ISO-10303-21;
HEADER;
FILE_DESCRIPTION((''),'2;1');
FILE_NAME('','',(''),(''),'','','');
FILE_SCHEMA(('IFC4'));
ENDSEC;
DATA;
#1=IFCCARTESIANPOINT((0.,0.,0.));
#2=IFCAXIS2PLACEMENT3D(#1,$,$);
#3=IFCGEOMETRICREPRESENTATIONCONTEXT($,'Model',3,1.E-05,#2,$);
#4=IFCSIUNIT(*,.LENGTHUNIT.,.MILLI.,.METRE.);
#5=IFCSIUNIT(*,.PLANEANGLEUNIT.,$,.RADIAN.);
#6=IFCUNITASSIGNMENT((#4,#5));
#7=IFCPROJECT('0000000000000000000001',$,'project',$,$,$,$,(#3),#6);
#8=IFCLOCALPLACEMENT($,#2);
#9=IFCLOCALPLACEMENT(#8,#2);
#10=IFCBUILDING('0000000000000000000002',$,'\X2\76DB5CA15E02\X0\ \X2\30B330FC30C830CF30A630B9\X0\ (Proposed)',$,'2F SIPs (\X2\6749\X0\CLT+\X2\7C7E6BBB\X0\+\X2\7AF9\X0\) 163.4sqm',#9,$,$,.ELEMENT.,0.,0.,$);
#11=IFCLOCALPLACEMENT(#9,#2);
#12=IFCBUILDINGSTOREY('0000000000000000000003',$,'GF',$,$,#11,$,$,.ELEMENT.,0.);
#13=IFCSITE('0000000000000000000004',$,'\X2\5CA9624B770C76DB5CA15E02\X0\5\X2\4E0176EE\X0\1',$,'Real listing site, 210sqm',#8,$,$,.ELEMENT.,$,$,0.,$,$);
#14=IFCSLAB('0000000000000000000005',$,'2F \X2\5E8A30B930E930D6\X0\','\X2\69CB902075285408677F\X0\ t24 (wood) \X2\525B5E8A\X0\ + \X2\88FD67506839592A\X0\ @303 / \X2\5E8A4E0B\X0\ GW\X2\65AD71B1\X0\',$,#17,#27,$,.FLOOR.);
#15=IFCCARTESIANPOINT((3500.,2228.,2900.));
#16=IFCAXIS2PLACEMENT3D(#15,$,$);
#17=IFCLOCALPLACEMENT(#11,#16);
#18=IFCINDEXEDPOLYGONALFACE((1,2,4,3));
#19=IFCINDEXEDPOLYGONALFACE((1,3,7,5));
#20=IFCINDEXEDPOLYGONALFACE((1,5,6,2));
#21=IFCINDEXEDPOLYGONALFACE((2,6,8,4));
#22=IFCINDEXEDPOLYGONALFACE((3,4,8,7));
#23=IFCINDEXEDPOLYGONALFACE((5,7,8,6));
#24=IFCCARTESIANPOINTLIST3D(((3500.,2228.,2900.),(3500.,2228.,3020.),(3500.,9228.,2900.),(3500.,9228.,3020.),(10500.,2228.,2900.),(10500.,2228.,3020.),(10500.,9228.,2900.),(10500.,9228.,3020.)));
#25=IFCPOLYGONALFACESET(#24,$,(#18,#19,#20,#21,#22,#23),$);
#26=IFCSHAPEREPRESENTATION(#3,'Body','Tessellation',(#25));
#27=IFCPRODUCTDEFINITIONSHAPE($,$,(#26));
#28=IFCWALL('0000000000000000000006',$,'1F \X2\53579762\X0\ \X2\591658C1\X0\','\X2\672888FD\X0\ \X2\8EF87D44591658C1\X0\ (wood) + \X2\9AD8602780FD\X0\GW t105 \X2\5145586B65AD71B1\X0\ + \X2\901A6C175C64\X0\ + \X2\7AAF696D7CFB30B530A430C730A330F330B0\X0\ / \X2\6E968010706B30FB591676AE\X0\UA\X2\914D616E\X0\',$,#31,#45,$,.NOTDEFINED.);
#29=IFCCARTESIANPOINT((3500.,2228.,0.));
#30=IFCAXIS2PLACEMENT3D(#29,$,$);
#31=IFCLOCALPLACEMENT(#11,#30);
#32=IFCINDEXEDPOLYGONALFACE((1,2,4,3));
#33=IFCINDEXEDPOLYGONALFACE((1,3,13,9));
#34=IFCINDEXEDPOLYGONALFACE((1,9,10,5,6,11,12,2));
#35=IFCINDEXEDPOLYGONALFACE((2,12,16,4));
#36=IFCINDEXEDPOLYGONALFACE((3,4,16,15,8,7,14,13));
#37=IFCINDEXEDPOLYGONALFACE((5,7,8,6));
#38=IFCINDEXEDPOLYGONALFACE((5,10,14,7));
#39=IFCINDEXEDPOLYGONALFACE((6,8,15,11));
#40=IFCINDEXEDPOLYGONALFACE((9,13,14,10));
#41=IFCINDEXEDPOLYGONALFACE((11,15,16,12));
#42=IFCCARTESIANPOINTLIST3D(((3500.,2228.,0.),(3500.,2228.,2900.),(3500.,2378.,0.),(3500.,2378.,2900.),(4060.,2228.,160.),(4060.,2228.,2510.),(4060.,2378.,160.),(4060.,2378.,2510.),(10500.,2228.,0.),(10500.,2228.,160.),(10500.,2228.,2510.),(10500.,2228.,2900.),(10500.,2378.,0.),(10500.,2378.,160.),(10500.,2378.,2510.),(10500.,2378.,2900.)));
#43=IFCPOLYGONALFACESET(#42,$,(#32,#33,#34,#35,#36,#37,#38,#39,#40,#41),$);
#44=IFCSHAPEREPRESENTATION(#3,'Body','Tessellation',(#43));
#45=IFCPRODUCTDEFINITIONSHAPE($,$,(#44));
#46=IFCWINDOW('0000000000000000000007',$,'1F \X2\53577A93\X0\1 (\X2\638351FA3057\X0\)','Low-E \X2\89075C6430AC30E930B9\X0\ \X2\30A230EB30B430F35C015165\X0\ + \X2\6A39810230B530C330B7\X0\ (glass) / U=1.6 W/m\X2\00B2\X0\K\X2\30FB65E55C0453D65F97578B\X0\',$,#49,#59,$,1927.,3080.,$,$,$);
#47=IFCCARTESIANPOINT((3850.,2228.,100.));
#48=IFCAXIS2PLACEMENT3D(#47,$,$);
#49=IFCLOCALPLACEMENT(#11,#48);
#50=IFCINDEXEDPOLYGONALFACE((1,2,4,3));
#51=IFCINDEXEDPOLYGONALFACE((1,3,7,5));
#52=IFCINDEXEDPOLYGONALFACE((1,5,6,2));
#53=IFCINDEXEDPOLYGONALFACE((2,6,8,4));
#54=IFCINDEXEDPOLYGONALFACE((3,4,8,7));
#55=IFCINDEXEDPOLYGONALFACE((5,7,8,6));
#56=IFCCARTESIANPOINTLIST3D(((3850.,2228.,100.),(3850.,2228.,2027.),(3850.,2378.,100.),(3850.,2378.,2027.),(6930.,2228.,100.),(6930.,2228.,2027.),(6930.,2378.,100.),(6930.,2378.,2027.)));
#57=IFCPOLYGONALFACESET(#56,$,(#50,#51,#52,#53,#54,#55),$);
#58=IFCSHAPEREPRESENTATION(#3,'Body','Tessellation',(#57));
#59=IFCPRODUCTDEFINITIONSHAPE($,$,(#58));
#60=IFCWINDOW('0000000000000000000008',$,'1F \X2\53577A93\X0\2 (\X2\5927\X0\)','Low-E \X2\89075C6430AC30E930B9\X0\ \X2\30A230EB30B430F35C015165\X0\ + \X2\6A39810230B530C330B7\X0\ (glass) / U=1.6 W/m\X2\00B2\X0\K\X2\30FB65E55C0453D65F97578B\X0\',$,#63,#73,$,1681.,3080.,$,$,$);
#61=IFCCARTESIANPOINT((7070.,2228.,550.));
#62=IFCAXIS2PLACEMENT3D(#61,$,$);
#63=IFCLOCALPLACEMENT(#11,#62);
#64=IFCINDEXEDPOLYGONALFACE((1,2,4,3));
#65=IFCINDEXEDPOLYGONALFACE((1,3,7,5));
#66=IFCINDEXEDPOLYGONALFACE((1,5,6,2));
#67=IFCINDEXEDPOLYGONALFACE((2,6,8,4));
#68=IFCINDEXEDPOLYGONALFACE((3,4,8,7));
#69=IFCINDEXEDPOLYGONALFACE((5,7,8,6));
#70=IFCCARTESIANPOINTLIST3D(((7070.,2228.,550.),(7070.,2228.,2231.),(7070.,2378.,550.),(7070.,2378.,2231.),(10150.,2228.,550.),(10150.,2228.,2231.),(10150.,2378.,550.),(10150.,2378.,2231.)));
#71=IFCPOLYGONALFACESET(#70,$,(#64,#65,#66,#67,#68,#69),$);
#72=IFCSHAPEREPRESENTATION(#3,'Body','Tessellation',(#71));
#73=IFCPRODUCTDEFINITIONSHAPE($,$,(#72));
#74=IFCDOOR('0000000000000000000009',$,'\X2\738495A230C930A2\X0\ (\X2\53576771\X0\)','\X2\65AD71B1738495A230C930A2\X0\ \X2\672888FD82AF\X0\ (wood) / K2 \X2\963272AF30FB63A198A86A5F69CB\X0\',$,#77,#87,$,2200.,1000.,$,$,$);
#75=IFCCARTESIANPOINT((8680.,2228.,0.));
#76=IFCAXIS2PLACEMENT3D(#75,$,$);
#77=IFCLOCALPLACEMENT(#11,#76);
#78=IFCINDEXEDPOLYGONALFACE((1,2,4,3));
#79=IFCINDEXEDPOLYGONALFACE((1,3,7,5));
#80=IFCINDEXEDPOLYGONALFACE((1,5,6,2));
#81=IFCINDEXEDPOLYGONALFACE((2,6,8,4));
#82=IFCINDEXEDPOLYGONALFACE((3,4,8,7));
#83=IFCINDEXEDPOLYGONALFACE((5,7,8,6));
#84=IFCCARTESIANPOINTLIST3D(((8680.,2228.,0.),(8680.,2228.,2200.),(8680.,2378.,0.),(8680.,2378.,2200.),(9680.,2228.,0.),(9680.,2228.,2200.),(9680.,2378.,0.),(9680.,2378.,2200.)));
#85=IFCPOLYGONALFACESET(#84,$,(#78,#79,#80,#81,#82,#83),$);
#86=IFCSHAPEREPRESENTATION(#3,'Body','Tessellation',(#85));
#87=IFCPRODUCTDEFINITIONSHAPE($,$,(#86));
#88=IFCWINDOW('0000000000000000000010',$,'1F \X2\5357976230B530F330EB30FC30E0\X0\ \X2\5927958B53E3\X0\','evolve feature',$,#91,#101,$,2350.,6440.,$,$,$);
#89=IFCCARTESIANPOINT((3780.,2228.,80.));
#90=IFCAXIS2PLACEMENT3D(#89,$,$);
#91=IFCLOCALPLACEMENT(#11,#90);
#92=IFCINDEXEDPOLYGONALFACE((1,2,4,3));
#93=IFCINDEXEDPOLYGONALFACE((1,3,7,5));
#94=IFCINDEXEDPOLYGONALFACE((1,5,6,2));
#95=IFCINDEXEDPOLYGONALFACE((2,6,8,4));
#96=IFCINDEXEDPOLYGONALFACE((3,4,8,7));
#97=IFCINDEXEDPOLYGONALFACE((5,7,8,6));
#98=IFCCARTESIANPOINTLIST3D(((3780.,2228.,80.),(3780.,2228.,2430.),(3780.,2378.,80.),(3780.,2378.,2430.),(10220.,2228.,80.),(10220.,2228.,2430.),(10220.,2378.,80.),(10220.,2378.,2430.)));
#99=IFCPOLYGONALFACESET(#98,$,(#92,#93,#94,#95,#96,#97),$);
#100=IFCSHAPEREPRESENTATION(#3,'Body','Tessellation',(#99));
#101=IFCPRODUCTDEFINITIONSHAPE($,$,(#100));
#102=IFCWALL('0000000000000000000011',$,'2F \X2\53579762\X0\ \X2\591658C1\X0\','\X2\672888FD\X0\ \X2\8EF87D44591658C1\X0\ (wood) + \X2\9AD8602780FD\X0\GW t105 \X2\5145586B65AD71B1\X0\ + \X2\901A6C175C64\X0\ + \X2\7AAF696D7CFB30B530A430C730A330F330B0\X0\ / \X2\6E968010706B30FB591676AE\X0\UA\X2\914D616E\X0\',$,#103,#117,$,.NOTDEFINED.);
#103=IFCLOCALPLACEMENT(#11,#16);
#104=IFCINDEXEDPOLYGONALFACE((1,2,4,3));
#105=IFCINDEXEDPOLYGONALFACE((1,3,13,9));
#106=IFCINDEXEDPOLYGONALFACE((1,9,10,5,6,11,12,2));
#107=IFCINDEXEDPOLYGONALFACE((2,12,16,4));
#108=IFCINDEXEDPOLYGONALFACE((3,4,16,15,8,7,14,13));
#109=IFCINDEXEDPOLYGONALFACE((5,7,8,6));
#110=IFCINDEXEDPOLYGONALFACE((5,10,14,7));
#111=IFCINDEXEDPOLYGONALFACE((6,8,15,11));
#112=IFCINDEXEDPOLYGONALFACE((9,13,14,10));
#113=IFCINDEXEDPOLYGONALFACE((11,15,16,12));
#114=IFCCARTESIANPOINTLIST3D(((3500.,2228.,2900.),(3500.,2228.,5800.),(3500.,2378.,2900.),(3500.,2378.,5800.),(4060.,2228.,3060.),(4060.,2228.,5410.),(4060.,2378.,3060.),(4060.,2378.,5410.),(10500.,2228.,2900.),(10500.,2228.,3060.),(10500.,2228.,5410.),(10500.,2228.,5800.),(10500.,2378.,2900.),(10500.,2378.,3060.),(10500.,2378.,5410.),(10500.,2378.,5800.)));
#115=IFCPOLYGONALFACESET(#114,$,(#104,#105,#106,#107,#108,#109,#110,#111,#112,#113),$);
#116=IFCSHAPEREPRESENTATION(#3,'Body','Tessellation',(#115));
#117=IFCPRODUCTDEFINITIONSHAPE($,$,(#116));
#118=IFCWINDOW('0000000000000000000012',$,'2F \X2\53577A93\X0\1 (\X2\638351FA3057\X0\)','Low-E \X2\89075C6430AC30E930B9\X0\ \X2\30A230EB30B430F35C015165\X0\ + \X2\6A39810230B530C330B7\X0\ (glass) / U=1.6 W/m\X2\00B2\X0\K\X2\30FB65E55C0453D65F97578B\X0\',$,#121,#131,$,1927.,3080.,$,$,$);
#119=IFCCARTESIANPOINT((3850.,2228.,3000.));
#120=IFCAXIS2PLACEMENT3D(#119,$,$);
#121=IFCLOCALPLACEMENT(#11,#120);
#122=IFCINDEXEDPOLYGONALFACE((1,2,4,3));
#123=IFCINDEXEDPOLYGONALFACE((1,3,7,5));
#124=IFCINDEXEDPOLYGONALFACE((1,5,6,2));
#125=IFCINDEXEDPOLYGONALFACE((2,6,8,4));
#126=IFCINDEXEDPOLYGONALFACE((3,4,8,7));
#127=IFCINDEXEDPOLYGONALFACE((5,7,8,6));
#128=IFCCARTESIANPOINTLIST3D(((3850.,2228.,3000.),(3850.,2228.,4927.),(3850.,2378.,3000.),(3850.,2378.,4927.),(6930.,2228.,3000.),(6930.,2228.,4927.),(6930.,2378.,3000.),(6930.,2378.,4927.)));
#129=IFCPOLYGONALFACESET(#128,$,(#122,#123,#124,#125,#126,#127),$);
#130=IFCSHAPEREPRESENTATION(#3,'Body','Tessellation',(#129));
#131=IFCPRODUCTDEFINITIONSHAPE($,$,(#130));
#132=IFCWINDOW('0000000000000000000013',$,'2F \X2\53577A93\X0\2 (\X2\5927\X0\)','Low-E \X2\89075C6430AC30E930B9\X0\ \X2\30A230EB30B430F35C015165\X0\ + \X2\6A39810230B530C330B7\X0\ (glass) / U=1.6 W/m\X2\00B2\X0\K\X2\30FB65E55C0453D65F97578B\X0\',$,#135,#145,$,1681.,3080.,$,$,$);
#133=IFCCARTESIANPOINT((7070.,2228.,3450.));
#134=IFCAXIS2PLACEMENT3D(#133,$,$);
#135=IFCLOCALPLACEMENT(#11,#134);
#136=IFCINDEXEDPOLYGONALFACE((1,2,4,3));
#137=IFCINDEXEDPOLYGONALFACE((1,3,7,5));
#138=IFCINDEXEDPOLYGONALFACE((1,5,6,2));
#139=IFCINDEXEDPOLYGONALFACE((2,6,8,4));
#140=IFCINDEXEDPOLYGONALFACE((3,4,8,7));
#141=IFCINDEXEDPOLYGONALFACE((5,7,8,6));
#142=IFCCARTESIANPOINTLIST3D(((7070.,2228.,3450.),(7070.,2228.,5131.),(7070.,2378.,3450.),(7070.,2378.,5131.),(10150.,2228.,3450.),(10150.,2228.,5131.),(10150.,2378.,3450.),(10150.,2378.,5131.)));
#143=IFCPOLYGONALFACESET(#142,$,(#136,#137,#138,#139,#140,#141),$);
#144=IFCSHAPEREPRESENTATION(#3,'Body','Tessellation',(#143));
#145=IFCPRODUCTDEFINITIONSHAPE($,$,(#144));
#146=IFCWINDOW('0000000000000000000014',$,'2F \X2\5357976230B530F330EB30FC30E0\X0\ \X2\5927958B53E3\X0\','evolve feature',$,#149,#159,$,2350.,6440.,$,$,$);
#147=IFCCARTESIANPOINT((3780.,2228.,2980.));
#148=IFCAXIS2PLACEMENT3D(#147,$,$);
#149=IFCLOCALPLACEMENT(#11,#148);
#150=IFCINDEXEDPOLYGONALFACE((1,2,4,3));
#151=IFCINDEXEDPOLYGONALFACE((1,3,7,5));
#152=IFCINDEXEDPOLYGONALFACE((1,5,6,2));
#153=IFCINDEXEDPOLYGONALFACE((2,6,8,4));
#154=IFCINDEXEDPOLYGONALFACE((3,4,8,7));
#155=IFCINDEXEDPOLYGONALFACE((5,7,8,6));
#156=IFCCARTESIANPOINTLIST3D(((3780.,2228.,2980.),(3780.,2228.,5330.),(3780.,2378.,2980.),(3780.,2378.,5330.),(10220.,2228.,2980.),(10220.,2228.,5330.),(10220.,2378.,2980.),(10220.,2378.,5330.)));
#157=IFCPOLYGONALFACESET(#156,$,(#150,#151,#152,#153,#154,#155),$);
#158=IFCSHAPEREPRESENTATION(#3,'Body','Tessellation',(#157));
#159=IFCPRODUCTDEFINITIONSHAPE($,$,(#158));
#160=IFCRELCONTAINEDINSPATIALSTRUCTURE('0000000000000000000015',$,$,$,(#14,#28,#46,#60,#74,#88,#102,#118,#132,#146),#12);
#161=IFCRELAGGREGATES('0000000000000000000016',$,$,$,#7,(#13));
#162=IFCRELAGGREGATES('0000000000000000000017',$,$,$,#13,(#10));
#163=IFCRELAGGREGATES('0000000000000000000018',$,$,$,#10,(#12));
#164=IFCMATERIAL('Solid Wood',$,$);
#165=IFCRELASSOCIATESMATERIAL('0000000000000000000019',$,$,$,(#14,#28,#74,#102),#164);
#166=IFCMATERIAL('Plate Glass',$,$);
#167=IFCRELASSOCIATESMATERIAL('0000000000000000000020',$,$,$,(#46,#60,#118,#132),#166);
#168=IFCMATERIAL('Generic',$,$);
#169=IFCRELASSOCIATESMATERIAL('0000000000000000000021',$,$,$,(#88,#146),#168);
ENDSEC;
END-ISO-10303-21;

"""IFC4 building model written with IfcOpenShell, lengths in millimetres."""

from ifc_helpers import new_model, si_unit, frame, frame_2d, origin, place, context, project, spatial, rectangle, extrude, material, element, fill, save


model = new_model("IFC4")

# Units and contexts
model_context = context("Model", 3, precision=1e-05, world=origin())
ifc_project = project(units=[si_unit("LENGTHUNIT", "METRE", prefix="MILLI"), si_unit("PLANEANGLEUNIT", "RADIAN")], contexts=[model_context])

# Site, building, storey
site_placement = place(None, origin())
site = spatial("IfcSite", under=ifc_project, at=site_placement, Name="岩手県盛岡市5丁目1", ObjectType="Real listing site, 210sqm", CompositionType="ELEMENT", RefElevation=0.0)
building_placement = place(site_placement, origin())
building = spatial("IfcBuilding", under=site, at=building_placement, Name="盛岡市 コートハウス (Proposed)", ObjectType="2F SIPs (杉CLT+籾殻+竹) 163.4sqm", CompositionType="ELEMENT", ElevationOfRefHeight=0.0, ElevationOfTerrain=0.0)
storey_placement = place(building_placement, origin())
storey = spatial("IfcBuildingStorey", under=building, at=storey_placement, Name="GF", CompositionType="ELEMENT", Elevation=0.0)

# Slab
ifc_material_1 = material(Name="Solid Wood")
slab_1_placement = place(storey_placement, frame((3500.0, 2228.0, 2900.0)))
element("IfcSlab", 1, at=slab_1_placement, inside=storey, material=ifc_material_1, Name="2F 床スラブ", Description="構造用合板 t24 (wood) 剛床 + 製材根太 @303 / 床下 GW断熱", PredefinedType="FLOOR", context=model_context, shape_type="SweptSolid", body=[
    extrude(rectangle(XDim=7000.0, YDim=7000.0, at=frame_2d((3500.0, 3500.0))), frame((3500.0, 2228.0, 2900.0)), (0.0, 0.0, 1.0), 120.0),
])
ifc_material_2 = material(Name="Generic")

# Wall, openings, windows, door
wall_1_placement = place(storey_placement, frame((3500.0, 2228.0, 0.0)))
wall_1 = element("IfcWall", 2, at=wall_1_placement, inside=storey, material=ifc_material_1, Name="1F 南面 外壁", Description="木製 軸組外壁 (wood) + 高性能GW t105 充填断熱 + 通気層 + 窯業系サイディング / 準耐火・外皮UA配慮", PredefinedType="NOTDEFINED", context=model_context, shape_type="SweptSolid", body=[
    extrude(rectangle(XDim=7000.0, YDim=150.0, at=frame_2d((3500.0, 75.0))), frame((3500.0, 2228.0, 0.0)), (0.0, 0.0, 1.0), 2900.0),
])
opening_1_placement = place(storey_placement, frame((3850.0, 2228.0, 100.0)))
opening_1 = element("IfcOpeningElement", 3, at=opening_1_placement, cuts=wall_1, PredefinedType="NOTDEFINED", context=model_context, shape_type="SweptSolid", body=[
    extrude(rectangle(XDim=3080.0, YDim=150.0, at=frame_2d((1540.0, 75.0))), frame((3850.0, 2228.0, 100.0)), (0.0, 0.0, 1.0), 1927.0),
])
opening_2_placement = place(storey_placement, frame((7070.0, 2228.0, 550.0)))
opening_2 = element("IfcOpeningElement", 4, at=opening_2_placement, cuts=wall_1, PredefinedType="NOTDEFINED", context=model_context, shape_type="SweptSolid", body=[
    extrude(rectangle(XDim=3080.0, YDim=150.0, at=frame_2d((1540.0, 75.0))), frame((7070.0, 2228.0, 550.0)), (0.0, 0.0, 1.0), 1681.0),
])
opening_3_placement = place(storey_placement, frame((8680.0, 2228.0, 0.0)))
opening_3 = element("IfcOpeningElement", 5, at=opening_3_placement, cuts=wall_1, PredefinedType="NOTDEFINED", context=model_context, shape_type="SweptSolid", body=[
    extrude(rectangle(XDim=1000.0, YDim=150.0, at=frame_2d((500.0, 75.0))), frame((8680.0, 2228.0, 0.0)), (0.0, 0.0, 1.0), 2200.0),
])
opening_4_placement = place(storey_placement, frame((3780.0, 2228.0, 80.0)))
opening_4 = element("IfcOpeningElement", 6, at=opening_4_placement, cuts=wall_1, PredefinedType="NOTDEFINED", context=model_context, shape_type="SweptSolid", body=[
    extrude(rectangle(XDim=6440.0, YDim=150.0, at=frame_2d((3220.0, 75.0))), frame((3780.0, 2228.0, 80.0)), (0.0, 0.0, 1.0), 2350.0),
])
ifc_material_3 = material(Name="Plate Glass")
window_1_placement = place(storey_placement, frame((3850.0, 2228.0, 100.0)))
window_1 = element("IfcWindow", 7, at=window_1_placement, inside=storey, material=ifc_material_3, Name="1F 南窓1 (掃出し)", Description="Low-E 複層ガラス アルゴン封入 + 樹脂サッシ (glass) / U=1.6 W/m²K・日射取得型", OverallHeight=1927.0, OverallWidth=3080.0, context=model_context, shape_type="SweptSolid", body=[
    extrude(rectangle(XDim=3080.0, YDim=150.0, at=frame_2d((1540.0, 75.0))), frame((3850.0, 2228.0, 100.0)), (0.0, 0.0, 1.0), 1927.0),
])
fill(opening_1, window_1)
window_2_placement = place(storey_placement, frame((7070.0, 2228.0, 550.0)))
window_2 = element("IfcWindow", 8, at=window_2_placement, inside=storey, material=ifc_material_3, Name="1F 南窓2 (大)", Description="Low-E 複層ガラス アルゴン封入 + 樹脂サッシ (glass) / U=1.6 W/m²K・日射取得型", OverallHeight=1681.0, OverallWidth=3080.0, context=model_context, shape_type="SweptSolid", body=[
    extrude(rectangle(XDim=3080.0, YDim=150.0, at=frame_2d((1540.0, 75.0))), frame((7070.0, 2228.0, 550.0)), (0.0, 0.0, 1.0), 1681.0),
])
fill(opening_2, window_2)
door_placement = place(storey_placement, frame((8680.0, 2228.0, 0.0)))
door = element("IfcDoor", 9, at=door_placement, inside=storey, material=ifc_material_1, Name="玄関ドア (南東)", Description="断熱玄関ドア 木製芯 (wood) / K2 防犯・採風機構", OverallHeight=2200.0, OverallWidth=1000.0, context=model_context, shape_type="SweptSolid", body=[
    extrude(rectangle(XDim=1000.0, YDim=150.0, at=frame_2d((500.0, 75.0))), frame((8680.0, 2228.0, 0.0)), (0.0, 0.0, 1.0), 2200.0),
])
fill(opening_3, door)
window_3_placement = place(storey_placement, frame((3780.0, 2228.0, 80.0)))
window_3 = element("IfcWindow", 10, at=window_3_placement, inside=storey, material=ifc_material_2, Name="1F 南面サンルーム 大開口", Description="evolve feature", OverallHeight=2350.0, OverallWidth=6440.0, context=model_context, shape_type="SweptSolid", body=[
    extrude(rectangle(XDim=6440.0, YDim=150.0, at=frame_2d((3220.0, 75.0))), frame((3780.0, 2228.0, 80.0)), (0.0, 0.0, 1.0), 2350.0),
])
fill(opening_4, window_3)

# Wall, openings, windows
wall_2_placement = place(storey_placement, frame((3500.0, 2228.0, 2900.0)))
wall_2 = element("IfcWall", 11, at=wall_2_placement, inside=storey, material=ifc_material_1, Name="2F 南面 外壁", Description="木製 軸組外壁 (wood) + 高性能GW t105 充填断熱 + 通気層 + 窯業系サイディング / 準耐火・外皮UA配慮", PredefinedType="NOTDEFINED", context=model_context, shape_type="SweptSolid", body=[
    extrude(rectangle(XDim=7000.0, YDim=150.0, at=frame_2d((3500.0, 75.0))), frame((3500.0, 2228.0, 2900.0)), (0.0, 0.0, 1.0), 2900.0),
])
opening_5_placement = place(storey_placement, frame((3850.0, 2228.0, 3000.0)))
opening_5 = element("IfcOpeningElement", 12, at=opening_5_placement, cuts=wall_2, PredefinedType="NOTDEFINED", context=model_context, shape_type="SweptSolid", body=[
    extrude(rectangle(XDim=3080.0, YDim=150.0, at=frame_2d((1540.0, 75.0))), frame((3850.0, 2228.0, 3000.0)), (0.0, 0.0, 1.0), 1927.0),
])
opening_6_placement = place(storey_placement, frame((7070.0, 2228.0, 3450.0)))
opening_6 = element("IfcOpeningElement", 13, at=opening_6_placement, cuts=wall_2, PredefinedType="NOTDEFINED", context=model_context, shape_type="SweptSolid", body=[
    extrude(rectangle(XDim=3080.0, YDim=150.0, at=frame_2d((1540.0, 75.0))), frame((7070.0, 2228.0, 3450.0)), (0.0, 0.0, 1.0), 1681.0),
])
opening_7_placement = place(storey_placement, frame((3780.0, 2228.0, 2980.0)))
opening_7 = element("IfcOpeningElement", 14, at=opening_7_placement, cuts=wall_2, PredefinedType="NOTDEFINED", context=model_context, shape_type="SweptSolid", body=[
    extrude(rectangle(XDim=6440.0, YDim=150.0, at=frame_2d((3220.0, 75.0))), frame((3780.0, 2228.0, 2980.0)), (0.0, 0.0, 1.0), 2350.0),
])
window_4_placement = place(storey_placement, frame((3850.0, 2228.0, 3000.0)))
window_4 = element("IfcWindow", 15, at=window_4_placement, inside=storey, material=ifc_material_3, Name="2F 南窓1 (掃出し)", Description="Low-E 複層ガラス アルゴン封入 + 樹脂サッシ (glass) / U=1.6 W/m²K・日射取得型", OverallHeight=1927.0, OverallWidth=3080.0, context=model_context, shape_type="SweptSolid", body=[
    extrude(rectangle(XDim=3080.0, YDim=150.0, at=frame_2d((1540.0, 75.0))), frame((3850.0, 2228.0, 3000.0)), (0.0, 0.0, 1.0), 1927.0),
])
fill(opening_5, window_4)
window_5_placement = place(storey_placement, frame((7070.0, 2228.0, 3450.0)))
window_5 = element("IfcWindow", 16, at=window_5_placement, inside=storey, material=ifc_material_3, Name="2F 南窓2 (大)", Description="Low-E 複層ガラス アルゴン封入 + 樹脂サッシ (glass) / U=1.6 W/m²K・日射取得型", OverallHeight=1681.0, OverallWidth=3080.0, context=model_context, shape_type="SweptSolid", body=[
    extrude(rectangle(XDim=3080.0, YDim=150.0, at=frame_2d((1540.0, 75.0))), frame((7070.0, 2228.0, 3450.0)), (0.0, 0.0, 1.0), 1681.0),
])
fill(opening_6, window_5)
window_6_placement = place(storey_placement, frame((3780.0, 2228.0, 2980.0)))
window_6 = element("IfcWindow", 17, at=window_6_placement, inside=storey, material=ifc_material_2, Name="2F 南面サンルーム 大開口", Description="evolve feature", OverallHeight=2350.0, OverallWidth=6440.0, context=model_context, shape_type="SweptSolid", body=[
    extrude(rectangle(XDim=6440.0, YDim=150.0, at=frame_2d((3220.0, 75.0))), frame((3780.0, 2228.0, 2980.0)), (0.0, 0.0, 1.0), 2350.0),
])
fill(opening_7, window_6)

save(model, "model.ifc")
